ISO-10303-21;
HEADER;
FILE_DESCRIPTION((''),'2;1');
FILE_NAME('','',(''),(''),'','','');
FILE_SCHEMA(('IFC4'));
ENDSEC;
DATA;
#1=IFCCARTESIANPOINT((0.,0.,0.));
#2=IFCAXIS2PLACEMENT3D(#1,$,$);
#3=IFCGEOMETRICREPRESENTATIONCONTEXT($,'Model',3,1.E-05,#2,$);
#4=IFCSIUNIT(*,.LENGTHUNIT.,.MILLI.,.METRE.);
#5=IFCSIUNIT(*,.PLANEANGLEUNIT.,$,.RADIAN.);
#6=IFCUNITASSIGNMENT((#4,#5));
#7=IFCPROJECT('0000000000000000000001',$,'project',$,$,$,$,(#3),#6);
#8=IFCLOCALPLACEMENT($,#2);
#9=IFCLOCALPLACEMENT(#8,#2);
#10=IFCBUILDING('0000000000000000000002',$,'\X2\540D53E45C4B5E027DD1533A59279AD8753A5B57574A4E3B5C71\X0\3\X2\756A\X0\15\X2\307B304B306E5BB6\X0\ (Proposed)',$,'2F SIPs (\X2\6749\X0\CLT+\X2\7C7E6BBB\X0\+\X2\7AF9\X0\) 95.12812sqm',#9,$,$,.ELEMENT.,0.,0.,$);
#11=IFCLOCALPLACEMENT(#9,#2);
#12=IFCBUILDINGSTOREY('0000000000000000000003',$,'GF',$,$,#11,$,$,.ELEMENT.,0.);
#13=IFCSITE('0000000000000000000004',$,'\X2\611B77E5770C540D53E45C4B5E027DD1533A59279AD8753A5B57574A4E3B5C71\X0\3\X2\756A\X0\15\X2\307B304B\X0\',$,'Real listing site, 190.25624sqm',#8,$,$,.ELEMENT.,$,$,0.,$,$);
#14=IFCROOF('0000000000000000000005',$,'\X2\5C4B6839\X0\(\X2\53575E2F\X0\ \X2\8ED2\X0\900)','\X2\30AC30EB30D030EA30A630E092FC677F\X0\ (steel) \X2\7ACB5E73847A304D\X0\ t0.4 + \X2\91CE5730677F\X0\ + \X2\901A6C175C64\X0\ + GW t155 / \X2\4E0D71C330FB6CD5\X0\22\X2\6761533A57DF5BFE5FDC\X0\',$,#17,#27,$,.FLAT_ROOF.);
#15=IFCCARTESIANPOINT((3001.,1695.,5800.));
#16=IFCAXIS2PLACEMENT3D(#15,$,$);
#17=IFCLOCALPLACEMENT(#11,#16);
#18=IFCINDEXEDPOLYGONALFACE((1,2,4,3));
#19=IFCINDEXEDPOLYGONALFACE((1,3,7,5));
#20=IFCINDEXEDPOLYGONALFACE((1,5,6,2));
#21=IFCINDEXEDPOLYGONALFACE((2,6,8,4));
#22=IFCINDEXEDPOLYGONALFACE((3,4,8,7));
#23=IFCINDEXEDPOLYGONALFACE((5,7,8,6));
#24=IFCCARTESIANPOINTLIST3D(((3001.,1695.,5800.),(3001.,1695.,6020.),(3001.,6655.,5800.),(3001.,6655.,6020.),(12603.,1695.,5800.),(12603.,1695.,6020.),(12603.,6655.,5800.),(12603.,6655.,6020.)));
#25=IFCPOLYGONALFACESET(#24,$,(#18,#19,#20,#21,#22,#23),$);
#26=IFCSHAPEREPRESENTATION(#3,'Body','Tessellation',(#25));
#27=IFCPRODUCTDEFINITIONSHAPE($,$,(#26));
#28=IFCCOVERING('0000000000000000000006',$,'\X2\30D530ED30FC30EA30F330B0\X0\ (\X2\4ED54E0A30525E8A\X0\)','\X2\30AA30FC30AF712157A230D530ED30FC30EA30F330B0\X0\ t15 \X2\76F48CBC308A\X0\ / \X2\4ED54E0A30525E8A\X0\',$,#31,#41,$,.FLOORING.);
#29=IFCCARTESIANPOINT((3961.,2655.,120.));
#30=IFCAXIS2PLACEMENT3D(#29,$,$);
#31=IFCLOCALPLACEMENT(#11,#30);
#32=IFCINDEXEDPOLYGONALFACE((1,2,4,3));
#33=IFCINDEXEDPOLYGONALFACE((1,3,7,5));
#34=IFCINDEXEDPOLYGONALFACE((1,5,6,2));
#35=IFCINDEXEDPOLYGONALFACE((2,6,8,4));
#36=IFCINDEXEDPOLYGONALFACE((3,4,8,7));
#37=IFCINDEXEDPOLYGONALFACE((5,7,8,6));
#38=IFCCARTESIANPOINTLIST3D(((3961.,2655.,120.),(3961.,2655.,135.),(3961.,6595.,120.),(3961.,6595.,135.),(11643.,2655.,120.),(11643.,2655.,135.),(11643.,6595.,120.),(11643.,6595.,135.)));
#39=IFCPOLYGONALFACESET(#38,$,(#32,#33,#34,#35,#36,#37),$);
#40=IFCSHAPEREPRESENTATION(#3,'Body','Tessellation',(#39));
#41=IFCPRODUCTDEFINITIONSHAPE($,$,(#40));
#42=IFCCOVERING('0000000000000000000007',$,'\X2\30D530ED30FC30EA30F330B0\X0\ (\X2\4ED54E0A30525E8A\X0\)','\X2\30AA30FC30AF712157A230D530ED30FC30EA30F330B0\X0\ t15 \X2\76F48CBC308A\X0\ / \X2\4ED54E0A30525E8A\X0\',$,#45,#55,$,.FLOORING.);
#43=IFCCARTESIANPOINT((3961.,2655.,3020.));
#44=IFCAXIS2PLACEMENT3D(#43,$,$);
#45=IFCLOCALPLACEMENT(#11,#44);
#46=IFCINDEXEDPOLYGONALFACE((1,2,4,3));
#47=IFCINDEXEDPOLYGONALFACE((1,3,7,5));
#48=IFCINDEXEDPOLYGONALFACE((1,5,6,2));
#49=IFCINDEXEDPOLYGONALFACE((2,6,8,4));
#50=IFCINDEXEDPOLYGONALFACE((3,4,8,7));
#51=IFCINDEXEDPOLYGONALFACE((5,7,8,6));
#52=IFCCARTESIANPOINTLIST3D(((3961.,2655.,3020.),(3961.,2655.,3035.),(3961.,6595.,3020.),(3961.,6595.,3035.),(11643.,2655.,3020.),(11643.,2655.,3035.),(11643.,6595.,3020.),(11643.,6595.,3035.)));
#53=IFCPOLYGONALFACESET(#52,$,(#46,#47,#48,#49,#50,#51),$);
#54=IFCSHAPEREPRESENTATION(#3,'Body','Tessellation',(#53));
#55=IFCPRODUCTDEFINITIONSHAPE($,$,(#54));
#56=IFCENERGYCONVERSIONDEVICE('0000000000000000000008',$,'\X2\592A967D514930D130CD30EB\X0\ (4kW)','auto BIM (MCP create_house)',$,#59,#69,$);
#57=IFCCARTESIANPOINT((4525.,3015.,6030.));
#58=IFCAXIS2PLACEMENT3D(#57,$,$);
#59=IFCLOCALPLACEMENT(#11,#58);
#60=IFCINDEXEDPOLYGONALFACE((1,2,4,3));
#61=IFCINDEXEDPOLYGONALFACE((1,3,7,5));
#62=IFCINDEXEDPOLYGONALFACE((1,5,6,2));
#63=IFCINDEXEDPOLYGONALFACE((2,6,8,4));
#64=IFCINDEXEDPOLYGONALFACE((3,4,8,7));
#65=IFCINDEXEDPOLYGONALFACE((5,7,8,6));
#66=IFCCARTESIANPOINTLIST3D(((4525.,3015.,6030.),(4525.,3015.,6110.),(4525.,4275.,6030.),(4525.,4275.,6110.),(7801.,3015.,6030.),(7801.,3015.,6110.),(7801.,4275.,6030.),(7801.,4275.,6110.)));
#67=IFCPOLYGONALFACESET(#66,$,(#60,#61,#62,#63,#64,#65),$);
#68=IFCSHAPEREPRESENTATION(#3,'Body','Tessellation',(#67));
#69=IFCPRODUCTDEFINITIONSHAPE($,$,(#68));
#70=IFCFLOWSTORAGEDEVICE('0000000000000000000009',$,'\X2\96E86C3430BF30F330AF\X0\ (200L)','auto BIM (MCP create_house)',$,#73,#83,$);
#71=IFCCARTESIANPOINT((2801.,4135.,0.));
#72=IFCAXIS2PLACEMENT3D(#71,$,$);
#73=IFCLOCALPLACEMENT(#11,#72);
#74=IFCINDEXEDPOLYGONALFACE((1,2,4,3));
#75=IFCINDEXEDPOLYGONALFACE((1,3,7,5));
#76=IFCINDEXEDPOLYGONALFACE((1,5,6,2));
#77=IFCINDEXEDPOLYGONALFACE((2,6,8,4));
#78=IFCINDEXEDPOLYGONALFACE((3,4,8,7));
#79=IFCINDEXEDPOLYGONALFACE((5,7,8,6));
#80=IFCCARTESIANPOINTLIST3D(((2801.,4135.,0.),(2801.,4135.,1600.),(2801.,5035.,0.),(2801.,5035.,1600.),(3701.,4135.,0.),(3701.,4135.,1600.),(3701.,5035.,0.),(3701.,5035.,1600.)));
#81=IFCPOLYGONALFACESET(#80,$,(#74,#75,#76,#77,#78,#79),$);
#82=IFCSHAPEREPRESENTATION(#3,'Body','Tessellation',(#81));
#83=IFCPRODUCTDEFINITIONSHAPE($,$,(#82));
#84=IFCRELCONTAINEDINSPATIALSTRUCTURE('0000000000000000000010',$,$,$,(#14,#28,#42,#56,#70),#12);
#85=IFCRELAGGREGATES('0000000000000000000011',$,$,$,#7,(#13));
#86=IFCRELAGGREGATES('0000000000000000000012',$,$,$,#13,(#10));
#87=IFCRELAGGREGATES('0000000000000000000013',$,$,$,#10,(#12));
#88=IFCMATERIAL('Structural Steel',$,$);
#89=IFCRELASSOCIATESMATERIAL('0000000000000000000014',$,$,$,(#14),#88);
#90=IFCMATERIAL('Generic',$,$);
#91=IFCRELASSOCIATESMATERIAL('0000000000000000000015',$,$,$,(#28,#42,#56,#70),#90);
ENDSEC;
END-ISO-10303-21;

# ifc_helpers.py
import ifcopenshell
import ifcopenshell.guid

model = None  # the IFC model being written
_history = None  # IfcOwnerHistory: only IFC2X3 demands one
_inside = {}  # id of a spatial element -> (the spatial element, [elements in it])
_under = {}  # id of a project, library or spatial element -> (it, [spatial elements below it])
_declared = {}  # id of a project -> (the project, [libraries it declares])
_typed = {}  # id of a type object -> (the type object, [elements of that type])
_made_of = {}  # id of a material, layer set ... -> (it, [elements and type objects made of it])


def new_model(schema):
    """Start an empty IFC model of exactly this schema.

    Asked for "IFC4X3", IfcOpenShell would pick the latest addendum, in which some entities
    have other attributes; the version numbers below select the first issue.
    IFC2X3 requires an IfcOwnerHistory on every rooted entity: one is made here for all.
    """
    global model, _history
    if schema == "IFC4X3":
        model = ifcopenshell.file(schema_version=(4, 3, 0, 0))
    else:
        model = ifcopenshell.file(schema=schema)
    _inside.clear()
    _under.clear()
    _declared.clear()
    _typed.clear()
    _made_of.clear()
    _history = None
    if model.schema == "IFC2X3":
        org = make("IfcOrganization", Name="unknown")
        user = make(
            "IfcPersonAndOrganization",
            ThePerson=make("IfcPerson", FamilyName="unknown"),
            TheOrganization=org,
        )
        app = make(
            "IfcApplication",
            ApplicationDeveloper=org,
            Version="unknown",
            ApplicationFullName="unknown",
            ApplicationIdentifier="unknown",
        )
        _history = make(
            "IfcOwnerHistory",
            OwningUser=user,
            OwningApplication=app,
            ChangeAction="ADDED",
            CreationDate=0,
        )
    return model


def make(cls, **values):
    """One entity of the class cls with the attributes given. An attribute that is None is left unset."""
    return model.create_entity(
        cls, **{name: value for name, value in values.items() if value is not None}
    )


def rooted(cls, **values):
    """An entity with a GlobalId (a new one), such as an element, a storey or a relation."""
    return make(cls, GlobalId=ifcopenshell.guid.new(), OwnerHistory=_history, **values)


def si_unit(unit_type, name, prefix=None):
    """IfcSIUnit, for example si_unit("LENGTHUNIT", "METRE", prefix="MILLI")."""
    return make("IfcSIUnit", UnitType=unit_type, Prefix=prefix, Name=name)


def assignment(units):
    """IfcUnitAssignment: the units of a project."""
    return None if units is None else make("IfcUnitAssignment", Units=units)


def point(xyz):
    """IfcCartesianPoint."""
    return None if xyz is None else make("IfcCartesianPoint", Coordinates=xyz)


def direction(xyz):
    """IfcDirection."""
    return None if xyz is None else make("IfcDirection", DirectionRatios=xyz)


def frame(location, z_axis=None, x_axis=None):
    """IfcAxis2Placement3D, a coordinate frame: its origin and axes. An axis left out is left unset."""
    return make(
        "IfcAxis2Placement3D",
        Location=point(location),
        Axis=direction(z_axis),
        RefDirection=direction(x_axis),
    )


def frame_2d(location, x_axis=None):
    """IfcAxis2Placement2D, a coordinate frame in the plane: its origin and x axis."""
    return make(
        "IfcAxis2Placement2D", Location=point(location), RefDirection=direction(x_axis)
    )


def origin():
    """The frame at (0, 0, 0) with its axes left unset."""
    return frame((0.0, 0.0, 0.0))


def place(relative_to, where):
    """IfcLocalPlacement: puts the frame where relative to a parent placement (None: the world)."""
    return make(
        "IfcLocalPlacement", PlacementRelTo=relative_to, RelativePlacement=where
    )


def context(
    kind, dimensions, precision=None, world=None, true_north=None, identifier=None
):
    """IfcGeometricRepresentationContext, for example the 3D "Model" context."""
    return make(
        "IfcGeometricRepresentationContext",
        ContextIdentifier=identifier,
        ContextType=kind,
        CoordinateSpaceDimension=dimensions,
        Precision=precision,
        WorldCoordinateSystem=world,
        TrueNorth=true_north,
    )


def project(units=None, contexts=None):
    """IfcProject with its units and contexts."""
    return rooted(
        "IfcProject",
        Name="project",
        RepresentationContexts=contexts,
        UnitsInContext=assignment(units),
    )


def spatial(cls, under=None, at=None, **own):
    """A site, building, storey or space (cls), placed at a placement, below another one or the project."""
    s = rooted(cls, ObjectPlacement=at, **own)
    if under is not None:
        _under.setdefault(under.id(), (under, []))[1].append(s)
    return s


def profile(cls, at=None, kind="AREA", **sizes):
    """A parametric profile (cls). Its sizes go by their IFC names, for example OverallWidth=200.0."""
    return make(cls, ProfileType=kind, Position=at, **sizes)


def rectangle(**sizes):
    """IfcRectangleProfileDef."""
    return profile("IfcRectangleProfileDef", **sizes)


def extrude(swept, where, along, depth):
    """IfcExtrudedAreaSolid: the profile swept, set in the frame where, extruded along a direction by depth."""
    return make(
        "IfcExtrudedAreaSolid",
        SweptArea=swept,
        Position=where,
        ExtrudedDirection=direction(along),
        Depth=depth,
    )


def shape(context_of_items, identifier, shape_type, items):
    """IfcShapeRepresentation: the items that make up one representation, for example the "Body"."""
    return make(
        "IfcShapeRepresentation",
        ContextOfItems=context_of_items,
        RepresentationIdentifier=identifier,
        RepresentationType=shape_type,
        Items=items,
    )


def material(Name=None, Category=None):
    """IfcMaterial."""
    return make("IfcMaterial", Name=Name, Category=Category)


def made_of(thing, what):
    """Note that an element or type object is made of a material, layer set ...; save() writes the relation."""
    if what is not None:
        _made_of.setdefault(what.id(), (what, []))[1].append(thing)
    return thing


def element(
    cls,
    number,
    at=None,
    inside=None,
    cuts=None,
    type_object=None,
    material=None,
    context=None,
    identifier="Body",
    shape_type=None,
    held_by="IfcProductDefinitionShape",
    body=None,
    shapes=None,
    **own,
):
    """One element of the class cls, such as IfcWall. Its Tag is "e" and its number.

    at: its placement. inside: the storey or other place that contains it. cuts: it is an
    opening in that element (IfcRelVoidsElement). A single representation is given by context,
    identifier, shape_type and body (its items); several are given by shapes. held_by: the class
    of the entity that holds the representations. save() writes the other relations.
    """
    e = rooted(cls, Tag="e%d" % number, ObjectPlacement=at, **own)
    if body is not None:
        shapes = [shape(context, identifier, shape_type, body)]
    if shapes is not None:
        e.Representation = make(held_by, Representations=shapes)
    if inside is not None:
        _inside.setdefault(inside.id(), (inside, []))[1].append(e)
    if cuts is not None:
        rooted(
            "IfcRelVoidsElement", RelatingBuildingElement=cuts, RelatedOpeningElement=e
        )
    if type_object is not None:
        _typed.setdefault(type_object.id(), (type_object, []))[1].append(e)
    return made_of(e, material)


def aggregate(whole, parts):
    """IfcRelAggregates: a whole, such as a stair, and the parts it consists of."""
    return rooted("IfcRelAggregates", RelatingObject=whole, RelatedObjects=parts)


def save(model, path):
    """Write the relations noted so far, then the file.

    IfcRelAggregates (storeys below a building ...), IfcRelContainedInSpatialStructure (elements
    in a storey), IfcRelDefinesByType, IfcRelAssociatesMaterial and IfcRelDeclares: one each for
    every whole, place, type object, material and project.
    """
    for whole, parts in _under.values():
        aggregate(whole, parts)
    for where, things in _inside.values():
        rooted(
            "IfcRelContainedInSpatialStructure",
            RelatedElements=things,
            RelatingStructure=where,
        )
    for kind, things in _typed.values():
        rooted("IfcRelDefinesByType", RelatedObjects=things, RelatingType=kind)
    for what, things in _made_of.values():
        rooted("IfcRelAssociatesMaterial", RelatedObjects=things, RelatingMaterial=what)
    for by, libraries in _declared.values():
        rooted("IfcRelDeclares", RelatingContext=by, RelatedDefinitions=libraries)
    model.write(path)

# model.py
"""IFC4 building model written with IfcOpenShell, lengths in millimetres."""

from ifc_helpers import new_model, si_unit, frame, frame_2d, origin, place, context, project, spatial, rectangle, extrude, material, element, save


model = new_model("IFC4")

# Units and contexts
model_context = context("Model", 3, precision=1e-05, world=origin())
ifc_project = project(units=[si_unit("LENGTHUNIT", "METRE", prefix="MILLI"), si_unit("PLANEANGLEUNIT", "RADIAN")], contexts=[model_context])

# Site, building, storey
site_placement = place(None, origin())
site = spatial("IfcSite", under=ifc_project, at=site_placement, Name="愛知県名古屋市緑区大高町字坊主山3番15ほか", ObjectType="Real listing site, 190.25624sqm", CompositionType="ELEMENT", RefElevation=0.0)
building_placement = place(site_placement, origin())
building = spatial("IfcBuilding", under=site, at=building_placement, Name="名古屋市緑区大高町字坊主山3番15ほかの家 (Proposed)", ObjectType="2F SIPs (杉CLT+籾殻+竹) 95.12812sqm", CompositionType="ELEMENT", ElevationOfRefHeight=0.0, ElevationOfTerrain=0.0)
storey_placement = place(building_placement, origin())
storey = spatial("IfcBuildingStorey", under=building, at=storey_placement, Name="GF", CompositionType="ELEMENT", Elevation=0.0)

# Roof
ifc_material_1 = material(Name="Structural Steel")
for number, where, name in (
    (1, (3001.0, 1695.0, 5800.0), "屋根(南帯 軒900)"),
):
    element("IfcRoof", number, at=place(storey_placement, frame(where)), inside=storey, material=ifc_material_1, Name=name, Description="ガルバリウム鋼板 (steel) 立平葺き t0.4 + 野地板 + 通気層 + GW t155 / 不燃・法22条区域対応", PredefinedType="FLAT_ROOF", context=model_context, shape_type="SweptSolid", body=[
        extrude(rectangle(XDim=9602.0, YDim=4960.0, at=frame_2d((4801.0, 2480.0))), frame((3001.0, 1695.0, 5800.0)), (0.0, 0.0, 1.0), 220.0),
    ])

# Coverings
ifc_material_2 = material(Name="Generic")
covering_1_placement = place(storey_placement, frame((3961.0, 2655.0, 120.0)))
element("IfcCovering", 2, at=covering_1_placement, inside=storey, material=ifc_material_2, Name="フローリング (仕上げ床)", Description="オーク無垢フローリング t15 直貼り / 仕上げ床", PredefinedType="FLOORING", context=model_context, shape_type="SweptSolid", body=[
    extrude(rectangle(XDim=7682.0, YDim=3940.0, at=frame_2d((3841.0, 1970.0))), frame((3961.0, 2655.0, 120.0)), (0.0, 0.0, 1.0), 15.0),
])
covering_2_placement = place(storey_placement, frame((3961.0, 2655.0, 3020.0)))
element("IfcCovering", 3, at=covering_2_placement, inside=storey, material=ifc_material_2, Name="フローリング (仕上げ床)", Description="オーク無垢フローリング t15 直貼り / 仕上げ床", PredefinedType="FLOORING", context=model_context, shape_type="SweptSolid", body=[
    extrude(rectangle(XDim=7682.0, YDim=3940.0, at=frame_2d((3841.0, 1970.0))), frame((3961.0, 2655.0, 3020.0)), (0.0, 0.0, 1.0), 15.0),
])

# Energy conversion device
energy_conversion_device_placement = place(storey_placement, frame((4525.0, 3015.0, 6030.0)))
element("IfcEnergyConversionDevice", 4, at=energy_conversion_device_placement, inside=storey, material=ifc_material_2, Name="太陽光パネル (4kW)", Description="auto BIM (MCP create_house)", context=model_context, shape_type="SweptSolid", body=[
    extrude(rectangle(XDim=3276.0, YDim=1260.0, at=frame_2d((1638.0, 630.0))), frame((4525.0, 3015.0, 6030.0)), (0.0, 0.0, 1.0), 80.0),
])

# Flow storage device
flow_storage_device_placement = place(storey_placement, frame((2801.0, 4135.0, 0.0)))
element("IfcFlowStorageDevice", 5, at=flow_storage_device_placement, inside=storey, material=ifc_material_2, Name="雨水タンク (200L)", Description="auto BIM (MCP create_house)", context=model_context, shape_type="SweptSolid", body=[
    extrude(rectangle(XDim=900.0, YDim=900.0, at=frame_2d((450.0, 450.0))), frame((2801.0, 4135.0, 0.0)), (0.0, 0.0, 1.0), 1600.0),
])

save(model, "model.ifc")
